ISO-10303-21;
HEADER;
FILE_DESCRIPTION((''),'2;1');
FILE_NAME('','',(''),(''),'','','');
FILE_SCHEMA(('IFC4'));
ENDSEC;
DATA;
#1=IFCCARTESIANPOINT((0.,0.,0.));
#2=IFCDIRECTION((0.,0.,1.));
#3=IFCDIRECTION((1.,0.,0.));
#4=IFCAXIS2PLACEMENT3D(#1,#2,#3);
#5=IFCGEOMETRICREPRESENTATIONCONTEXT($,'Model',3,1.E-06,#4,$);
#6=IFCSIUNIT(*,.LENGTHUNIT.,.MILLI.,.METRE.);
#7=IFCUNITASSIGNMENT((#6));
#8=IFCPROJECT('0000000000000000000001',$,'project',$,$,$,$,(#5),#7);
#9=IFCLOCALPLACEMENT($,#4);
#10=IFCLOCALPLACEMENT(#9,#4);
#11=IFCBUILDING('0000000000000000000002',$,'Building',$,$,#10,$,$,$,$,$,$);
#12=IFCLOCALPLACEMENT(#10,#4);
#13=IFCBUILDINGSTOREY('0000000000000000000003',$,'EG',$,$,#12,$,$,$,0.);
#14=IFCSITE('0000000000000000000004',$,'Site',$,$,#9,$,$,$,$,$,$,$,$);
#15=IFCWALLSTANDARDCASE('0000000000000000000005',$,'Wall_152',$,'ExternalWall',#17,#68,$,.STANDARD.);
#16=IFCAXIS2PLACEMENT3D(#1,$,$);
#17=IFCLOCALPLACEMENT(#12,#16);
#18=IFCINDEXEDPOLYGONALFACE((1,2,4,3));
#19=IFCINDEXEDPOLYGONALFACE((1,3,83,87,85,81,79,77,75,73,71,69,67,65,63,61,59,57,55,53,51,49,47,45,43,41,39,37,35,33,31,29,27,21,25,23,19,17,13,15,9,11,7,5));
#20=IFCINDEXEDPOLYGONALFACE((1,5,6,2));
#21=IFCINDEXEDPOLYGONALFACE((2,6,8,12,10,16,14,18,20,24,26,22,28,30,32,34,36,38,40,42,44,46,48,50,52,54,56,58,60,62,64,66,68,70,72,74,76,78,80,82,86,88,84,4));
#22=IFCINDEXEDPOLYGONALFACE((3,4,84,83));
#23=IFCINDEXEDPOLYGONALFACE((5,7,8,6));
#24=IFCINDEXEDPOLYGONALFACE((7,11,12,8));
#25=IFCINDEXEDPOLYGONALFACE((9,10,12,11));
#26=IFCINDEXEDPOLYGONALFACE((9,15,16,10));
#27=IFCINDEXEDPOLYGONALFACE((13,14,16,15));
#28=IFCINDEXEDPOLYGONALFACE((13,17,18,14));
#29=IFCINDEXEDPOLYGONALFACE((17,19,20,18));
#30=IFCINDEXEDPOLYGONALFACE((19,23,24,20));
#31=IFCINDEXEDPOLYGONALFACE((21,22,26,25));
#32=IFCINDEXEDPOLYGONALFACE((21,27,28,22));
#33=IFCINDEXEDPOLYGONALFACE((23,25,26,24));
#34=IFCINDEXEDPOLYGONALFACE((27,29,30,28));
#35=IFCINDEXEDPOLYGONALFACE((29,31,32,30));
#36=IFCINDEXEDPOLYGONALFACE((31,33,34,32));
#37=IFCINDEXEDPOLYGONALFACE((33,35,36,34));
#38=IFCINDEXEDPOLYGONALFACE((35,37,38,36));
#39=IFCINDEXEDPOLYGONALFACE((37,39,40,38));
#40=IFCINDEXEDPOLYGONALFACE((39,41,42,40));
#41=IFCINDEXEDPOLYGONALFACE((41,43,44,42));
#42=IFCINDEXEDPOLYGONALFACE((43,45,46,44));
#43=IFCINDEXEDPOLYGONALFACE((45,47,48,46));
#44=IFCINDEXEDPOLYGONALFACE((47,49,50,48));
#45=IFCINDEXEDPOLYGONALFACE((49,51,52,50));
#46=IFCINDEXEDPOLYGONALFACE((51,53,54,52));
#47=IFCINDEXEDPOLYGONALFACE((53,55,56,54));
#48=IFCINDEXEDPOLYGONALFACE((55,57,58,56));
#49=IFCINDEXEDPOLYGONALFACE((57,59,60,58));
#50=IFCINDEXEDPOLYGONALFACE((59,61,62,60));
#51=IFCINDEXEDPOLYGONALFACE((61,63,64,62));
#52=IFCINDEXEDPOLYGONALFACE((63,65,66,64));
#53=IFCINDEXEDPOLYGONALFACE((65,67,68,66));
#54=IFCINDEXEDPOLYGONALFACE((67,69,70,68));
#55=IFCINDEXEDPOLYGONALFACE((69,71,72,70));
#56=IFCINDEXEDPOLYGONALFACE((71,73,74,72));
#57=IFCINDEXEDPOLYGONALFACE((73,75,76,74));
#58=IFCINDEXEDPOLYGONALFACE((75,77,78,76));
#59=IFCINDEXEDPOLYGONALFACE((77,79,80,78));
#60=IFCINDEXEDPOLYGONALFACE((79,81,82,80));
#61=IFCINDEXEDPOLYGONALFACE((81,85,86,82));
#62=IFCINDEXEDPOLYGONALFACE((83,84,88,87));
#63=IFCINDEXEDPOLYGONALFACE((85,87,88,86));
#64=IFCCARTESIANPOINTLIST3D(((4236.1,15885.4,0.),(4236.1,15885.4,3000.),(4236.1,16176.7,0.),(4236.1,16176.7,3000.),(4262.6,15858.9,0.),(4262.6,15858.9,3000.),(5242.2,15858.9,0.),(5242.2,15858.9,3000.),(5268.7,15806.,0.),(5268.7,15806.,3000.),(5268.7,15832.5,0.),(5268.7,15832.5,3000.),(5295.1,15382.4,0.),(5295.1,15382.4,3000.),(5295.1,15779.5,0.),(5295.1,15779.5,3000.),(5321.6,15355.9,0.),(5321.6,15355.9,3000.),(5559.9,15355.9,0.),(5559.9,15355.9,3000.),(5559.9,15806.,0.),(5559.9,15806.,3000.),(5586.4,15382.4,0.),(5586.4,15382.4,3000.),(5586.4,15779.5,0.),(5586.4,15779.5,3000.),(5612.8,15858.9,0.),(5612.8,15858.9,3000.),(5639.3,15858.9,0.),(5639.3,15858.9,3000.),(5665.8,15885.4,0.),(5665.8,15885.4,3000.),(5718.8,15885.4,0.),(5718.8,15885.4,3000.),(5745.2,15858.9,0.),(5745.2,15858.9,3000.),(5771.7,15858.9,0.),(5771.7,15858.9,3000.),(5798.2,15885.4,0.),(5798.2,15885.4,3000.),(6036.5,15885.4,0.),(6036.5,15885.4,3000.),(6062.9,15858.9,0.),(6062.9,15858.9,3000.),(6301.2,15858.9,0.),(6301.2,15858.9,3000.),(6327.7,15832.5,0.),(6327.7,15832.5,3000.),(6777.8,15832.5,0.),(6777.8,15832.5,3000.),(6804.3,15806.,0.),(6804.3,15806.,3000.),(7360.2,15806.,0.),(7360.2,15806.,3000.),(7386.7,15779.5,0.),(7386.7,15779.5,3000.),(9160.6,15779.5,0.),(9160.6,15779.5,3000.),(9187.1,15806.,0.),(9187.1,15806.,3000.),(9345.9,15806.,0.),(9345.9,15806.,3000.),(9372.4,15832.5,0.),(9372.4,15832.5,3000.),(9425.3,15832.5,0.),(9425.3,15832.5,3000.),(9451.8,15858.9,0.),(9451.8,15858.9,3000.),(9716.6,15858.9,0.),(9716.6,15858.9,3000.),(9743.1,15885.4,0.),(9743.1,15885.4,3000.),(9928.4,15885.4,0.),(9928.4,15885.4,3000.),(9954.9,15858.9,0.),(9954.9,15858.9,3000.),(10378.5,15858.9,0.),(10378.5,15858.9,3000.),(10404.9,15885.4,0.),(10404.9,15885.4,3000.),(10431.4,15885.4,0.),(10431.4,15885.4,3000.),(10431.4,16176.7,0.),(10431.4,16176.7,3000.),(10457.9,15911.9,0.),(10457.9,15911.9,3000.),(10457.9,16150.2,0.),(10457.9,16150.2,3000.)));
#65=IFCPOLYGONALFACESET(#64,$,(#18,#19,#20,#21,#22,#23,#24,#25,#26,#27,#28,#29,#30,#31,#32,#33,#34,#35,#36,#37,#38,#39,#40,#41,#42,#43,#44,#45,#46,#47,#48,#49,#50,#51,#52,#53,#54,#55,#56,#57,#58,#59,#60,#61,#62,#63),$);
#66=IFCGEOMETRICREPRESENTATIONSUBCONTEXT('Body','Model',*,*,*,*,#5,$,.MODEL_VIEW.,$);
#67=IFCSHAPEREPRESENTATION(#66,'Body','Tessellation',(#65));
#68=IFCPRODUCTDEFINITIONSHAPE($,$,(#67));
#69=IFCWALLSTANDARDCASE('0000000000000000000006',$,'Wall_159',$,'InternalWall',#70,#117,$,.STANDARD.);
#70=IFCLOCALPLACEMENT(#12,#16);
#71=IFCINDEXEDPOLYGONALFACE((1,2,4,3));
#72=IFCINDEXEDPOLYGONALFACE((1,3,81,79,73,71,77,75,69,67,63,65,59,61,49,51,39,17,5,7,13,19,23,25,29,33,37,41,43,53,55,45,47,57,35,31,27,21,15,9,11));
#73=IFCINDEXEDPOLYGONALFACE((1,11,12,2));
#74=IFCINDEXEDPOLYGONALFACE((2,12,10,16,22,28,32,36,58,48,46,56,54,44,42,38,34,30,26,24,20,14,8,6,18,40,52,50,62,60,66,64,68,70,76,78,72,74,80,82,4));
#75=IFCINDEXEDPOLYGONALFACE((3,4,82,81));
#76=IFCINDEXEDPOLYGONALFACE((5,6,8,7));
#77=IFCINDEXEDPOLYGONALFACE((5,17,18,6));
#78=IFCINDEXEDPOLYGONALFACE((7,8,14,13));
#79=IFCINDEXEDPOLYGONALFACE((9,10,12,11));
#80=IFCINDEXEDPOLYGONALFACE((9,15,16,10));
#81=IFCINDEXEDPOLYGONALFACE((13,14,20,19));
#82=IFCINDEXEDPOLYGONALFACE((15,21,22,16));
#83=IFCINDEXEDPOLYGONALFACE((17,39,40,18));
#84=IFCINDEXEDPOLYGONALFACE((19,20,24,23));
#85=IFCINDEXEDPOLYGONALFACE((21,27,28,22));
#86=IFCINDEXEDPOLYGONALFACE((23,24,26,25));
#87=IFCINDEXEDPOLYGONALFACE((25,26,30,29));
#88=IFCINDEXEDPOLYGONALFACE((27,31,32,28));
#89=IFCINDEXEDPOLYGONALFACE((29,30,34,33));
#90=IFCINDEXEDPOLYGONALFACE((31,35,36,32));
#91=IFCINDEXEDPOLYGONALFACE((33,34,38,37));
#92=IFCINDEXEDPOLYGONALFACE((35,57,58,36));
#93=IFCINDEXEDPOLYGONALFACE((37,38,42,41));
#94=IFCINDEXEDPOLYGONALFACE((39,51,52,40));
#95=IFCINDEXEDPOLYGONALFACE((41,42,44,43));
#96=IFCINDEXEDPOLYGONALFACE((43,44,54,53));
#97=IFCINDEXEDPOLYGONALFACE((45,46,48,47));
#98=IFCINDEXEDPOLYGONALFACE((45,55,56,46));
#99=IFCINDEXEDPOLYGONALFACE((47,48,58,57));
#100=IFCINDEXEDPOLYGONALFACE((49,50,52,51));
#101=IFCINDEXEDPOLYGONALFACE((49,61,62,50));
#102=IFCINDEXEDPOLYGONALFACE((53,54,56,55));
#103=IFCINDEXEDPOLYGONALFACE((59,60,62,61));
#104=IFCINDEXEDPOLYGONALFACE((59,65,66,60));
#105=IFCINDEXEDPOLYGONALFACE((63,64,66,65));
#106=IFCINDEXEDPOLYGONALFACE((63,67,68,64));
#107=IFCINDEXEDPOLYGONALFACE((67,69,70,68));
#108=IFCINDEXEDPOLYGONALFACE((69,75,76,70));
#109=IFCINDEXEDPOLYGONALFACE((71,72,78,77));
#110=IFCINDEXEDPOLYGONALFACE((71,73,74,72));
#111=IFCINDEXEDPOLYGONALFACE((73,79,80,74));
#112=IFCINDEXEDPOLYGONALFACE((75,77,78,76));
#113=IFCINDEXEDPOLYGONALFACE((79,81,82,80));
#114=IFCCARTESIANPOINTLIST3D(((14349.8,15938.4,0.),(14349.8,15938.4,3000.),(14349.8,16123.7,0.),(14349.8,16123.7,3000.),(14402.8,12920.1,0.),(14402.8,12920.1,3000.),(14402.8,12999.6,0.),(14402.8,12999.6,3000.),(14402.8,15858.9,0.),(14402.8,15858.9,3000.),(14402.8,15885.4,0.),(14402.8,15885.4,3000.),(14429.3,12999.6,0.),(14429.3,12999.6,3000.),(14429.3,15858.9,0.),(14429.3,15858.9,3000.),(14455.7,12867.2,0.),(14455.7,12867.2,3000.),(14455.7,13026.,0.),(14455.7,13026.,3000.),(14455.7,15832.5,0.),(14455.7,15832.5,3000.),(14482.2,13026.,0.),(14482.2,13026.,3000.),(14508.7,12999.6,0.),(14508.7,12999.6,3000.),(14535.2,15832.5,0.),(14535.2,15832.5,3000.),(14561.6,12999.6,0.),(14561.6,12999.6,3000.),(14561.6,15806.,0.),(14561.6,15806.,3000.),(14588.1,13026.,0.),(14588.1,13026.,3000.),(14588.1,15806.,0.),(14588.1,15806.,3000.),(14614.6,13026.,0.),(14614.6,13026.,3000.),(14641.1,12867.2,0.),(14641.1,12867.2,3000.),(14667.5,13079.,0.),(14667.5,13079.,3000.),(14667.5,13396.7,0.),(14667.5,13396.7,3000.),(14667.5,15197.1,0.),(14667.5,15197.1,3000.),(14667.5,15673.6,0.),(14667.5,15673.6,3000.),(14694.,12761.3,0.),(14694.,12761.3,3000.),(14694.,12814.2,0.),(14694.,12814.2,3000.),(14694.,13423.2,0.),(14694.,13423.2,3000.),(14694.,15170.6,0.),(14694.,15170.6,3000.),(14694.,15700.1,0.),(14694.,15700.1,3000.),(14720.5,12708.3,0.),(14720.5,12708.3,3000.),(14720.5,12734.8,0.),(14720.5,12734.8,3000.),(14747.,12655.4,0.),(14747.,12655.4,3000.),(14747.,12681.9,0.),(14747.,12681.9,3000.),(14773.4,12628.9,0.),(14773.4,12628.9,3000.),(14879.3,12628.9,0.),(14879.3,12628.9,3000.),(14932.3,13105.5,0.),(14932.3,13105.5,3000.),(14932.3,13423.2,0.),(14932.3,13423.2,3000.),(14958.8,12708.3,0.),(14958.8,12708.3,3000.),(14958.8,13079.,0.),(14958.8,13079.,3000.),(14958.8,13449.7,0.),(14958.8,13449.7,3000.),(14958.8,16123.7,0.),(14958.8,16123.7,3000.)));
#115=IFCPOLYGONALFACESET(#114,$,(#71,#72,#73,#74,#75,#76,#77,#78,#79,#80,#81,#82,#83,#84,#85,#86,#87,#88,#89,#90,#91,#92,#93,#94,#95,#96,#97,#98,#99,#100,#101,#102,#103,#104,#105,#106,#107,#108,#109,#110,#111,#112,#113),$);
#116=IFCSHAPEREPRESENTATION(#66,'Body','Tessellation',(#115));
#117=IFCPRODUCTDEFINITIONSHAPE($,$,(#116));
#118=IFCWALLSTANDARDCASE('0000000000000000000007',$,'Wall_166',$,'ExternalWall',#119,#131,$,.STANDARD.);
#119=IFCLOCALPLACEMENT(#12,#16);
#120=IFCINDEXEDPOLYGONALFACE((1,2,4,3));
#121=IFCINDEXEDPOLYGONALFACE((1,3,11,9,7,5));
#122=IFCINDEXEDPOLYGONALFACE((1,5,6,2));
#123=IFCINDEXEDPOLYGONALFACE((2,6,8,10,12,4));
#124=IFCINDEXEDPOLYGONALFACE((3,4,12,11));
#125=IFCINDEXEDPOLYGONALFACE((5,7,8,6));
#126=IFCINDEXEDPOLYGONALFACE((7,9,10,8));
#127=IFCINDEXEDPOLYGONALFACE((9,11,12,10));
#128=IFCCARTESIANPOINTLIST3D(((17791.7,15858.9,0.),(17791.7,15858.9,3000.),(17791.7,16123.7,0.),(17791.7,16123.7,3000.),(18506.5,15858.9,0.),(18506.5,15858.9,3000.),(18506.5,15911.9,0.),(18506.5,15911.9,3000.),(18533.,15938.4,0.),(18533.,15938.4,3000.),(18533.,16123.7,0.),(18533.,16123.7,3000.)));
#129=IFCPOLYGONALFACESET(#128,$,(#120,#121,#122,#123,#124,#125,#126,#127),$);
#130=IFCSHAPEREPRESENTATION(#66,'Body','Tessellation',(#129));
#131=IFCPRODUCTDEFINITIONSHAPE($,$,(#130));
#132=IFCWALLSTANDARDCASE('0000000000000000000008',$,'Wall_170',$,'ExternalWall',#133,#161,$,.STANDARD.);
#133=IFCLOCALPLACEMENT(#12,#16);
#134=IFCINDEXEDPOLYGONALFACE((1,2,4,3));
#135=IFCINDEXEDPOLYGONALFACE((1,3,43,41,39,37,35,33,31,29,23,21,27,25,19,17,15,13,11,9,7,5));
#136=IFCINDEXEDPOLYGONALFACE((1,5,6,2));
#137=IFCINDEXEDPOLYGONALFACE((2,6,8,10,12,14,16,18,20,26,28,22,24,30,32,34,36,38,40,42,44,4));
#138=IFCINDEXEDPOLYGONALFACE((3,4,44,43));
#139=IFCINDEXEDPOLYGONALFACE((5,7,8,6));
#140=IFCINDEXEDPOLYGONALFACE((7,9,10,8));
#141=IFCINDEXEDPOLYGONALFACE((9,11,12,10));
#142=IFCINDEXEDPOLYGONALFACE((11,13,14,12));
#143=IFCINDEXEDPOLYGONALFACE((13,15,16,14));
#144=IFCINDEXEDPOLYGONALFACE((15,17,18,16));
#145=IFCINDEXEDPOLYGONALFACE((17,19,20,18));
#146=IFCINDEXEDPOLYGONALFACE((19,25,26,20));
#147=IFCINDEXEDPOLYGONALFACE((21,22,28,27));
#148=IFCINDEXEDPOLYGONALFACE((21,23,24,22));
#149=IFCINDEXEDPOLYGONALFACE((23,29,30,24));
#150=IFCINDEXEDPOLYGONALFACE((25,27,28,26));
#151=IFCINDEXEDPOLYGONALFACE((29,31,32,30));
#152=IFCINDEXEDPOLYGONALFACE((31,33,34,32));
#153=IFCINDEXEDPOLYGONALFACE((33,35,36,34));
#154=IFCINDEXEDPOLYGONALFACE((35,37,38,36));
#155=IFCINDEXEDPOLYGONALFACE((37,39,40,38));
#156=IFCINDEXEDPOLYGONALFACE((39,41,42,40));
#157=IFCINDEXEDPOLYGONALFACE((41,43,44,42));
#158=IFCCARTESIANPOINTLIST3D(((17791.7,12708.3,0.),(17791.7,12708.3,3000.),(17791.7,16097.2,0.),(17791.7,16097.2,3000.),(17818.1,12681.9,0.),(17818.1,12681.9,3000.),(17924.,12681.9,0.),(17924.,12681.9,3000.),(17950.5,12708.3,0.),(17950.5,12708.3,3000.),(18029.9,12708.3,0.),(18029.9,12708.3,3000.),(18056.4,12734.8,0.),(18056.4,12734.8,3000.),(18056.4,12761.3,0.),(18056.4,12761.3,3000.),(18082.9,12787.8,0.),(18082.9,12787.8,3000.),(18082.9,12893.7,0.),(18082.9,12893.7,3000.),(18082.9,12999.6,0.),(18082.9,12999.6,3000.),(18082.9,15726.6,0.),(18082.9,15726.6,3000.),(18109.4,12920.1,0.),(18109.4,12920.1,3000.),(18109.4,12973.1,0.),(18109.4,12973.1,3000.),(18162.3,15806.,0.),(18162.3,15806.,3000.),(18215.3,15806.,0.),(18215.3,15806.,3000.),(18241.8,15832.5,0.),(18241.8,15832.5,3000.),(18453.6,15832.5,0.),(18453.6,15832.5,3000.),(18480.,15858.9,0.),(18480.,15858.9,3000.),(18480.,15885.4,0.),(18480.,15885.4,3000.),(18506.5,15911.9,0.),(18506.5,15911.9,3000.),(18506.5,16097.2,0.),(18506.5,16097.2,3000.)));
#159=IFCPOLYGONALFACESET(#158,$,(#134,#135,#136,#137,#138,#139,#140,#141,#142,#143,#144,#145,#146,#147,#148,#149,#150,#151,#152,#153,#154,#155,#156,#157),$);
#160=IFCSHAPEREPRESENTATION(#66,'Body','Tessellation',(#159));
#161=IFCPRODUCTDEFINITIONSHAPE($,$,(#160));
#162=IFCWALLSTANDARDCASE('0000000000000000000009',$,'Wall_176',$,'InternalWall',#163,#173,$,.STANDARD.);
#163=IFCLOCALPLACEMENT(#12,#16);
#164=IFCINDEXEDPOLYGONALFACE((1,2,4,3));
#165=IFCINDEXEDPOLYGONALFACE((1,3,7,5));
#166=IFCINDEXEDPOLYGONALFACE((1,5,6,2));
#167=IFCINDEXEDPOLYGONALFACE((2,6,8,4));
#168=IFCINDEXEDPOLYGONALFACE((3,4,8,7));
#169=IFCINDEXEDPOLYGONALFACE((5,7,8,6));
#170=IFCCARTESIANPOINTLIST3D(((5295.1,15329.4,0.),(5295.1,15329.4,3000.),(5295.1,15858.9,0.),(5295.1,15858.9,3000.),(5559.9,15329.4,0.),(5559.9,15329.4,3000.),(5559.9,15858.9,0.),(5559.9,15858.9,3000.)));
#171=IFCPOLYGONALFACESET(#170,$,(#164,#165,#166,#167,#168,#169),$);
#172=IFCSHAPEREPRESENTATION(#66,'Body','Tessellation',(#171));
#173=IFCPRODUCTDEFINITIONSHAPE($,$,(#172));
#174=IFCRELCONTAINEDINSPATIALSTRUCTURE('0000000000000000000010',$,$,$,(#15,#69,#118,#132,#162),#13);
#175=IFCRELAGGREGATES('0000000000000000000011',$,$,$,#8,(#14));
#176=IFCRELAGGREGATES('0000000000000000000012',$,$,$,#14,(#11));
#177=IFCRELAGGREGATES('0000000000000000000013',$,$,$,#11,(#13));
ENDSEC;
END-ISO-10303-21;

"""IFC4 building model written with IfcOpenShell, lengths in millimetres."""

from ifc_helpers import new_model, si_unit, frame, origin_with_axes, place, context, subcontext, project, spatial, polyline, outline, extrude, element, save


model = new_model("IFC4")

# Units and contexts
model_context = context("Model", 3, precision=1e-06, world=origin_with_axes())
body_context = subcontext(model_context, "Body", "Model", "MODEL_VIEW")
ifc_project = project(units=[si_unit("LENGTHUNIT", "METRE", prefix="MILLI")], contexts=[model_context])

# Site, building, storey
site_placement = place(None, origin_with_axes())
site = spatial("IfcSite", under=ifc_project, at=site_placement, Name="Site")
building_placement = place(site_placement, origin_with_axes())
building = spatial("IfcBuilding", under=site, at=building_placement, Name="Building")
storey_placement = place(building_placement, origin_with_axes())
storey = spatial("IfcBuildingStorey", under=building, at=storey_placement, Name="EG", Elevation=0.0)

# Walls
wall_1_placement = place(storey_placement, origin_with_axes())
element("IfcWallStandardCase", 1, at=wall_1_placement, inside=storey, Name="Wall_152", ObjectType="ExternalWall", PredefinedType="STANDARD", context=body_context, shape_type="SweptSolid", body=[
    extrude(outline(polyline([(5321.6, 15355.9, 0.0), (5295.1, 15382.4, 0.0), (5295.1, 15779.5, 0.0), (5268.7, 15806.0, 0.0), (5268.7, 15832.5, 0.0), (5242.2, 15858.9, 0.0), (4262.6, 15858.9, 0.0), (4236.1, 15885.4, 0.0), (4236.1, 16176.7, 0.0), (10431.4, 16176.7, 0.0), (10457.9, 16150.2, 0.0), (10457.9, 15911.9, 0.0), (10431.4, 15885.4, 0.0), (10404.9, 15885.4, 0.0), (10378.5, 15858.9, 0.0), (9954.9, 15858.9, 0.0), (9928.4, 15885.4, 0.0), (9743.1, 15885.4, 0.0), (9716.6, 15858.9, 0.0), (9451.8, 15858.9, 0.0), (9425.3, 15832.5, 0.0), (9372.4, 15832.5, 0.0), (9345.9, 15806.0, 0.0), (9187.1, 15806.0, 0.0), (9160.6, 15779.5, 0.0), (7386.7, 15779.5, 0.0), (7360.2, 15806.0, 0.0), (6804.3, 15806.0, 0.0), (6777.8, 15832.5, 0.0), (6327.7, 15832.5, 0.0), (6301.2, 15858.9, 0.0), (6062.9, 15858.9, 0.0), (6036.5, 15885.4, 0.0), (5798.2, 15885.4, 0.0), (5771.7, 15858.9, 0.0), (5745.2, 15858.9, 0.0), (5718.8, 15885.4, 0.0), (5665.8, 15885.4, 0.0), (5639.3, 15858.9, 0.0), (5612.8, 15858.9, 0.0), (5559.9, 15806.0, 0.0), (5586.4, 15779.5, 0.0), (5586.4, 15382.4, 0.0), (5559.9, 15355.9, 0.0), (5321.6, 15355.9, 0.0)])), origin_with_axes(), (0.0, 0.0, 1.0), 3000.0),
])
wall_2_placement = place(storey_placement, origin_with_axes())
element("IfcWallStandardCase", 2, at=wall_2_placement, inside=storey, Name="Wall_159", ObjectType="InternalWall", PredefinedType="STANDARD", context=body_context, shape_type="SweptSolid", body=[
    extrude(outline(polyline([(14773.4, 12628.9, 0.0), (14747.0, 12655.4, 0.0), (14747.0, 12681.9, 0.0), (14720.5, 12708.3, 0.0), (14720.5, 12734.8, 0.0), (14694.0, 12761.3, 0.0), (14694.0, 12814.2, 0.0), (14641.1, 12867.2, 0.0), (14455.7, 12867.2, 0.0), (14402.8, 12920.1, 0.0), (14402.8, 12999.6, 0.0), (14429.3, 12999.6, 0.0), (14455.7, 13026.0, 0.0), (14482.2, 13026.0, 0.0), (14508.7, 12999.6, 0.0), (14561.6, 12999.6, 0.0), (14588.1, 13026.0, 0.0), (14614.6, 13026.0, 0.0), (14667.5, 13079.0, 0.0), (14667.5, 13396.7, 0.0), (14694.0, 13423.2, 0.0), (14694.0, 15170.6, 0.0), (14667.5, 15197.1, 0.0), (14667.5, 15673.6, 0.0), (14694.0, 15700.1, 0.0), (14588.1, 15806.0, 0.0), (14561.6, 15806.0, 0.0), (14535.2, 15832.5, 0.0), (14455.7, 15832.5, 0.0), (14429.3, 15858.9, 0.0), (14402.8, 15858.9, 0.0), (14402.8, 15885.4, 0.0), (14349.8, 15938.4, 0.0), (14349.8, 16123.7, 0.0), (14958.8, 16123.7, 0.0), (14958.8, 13449.7, 0.0), (14932.3, 13423.2, 0.0), (14932.3, 13105.5, 0.0), (14958.8, 13079.0, 0.0), (14958.8, 12708.3, 0.0), (14879.3, 12628.9, 0.0), (14773.4, 12628.9, 0.0)])), origin_with_axes(), (0.0, 0.0, 1.0), 3000.0),
])
for number, where, z_axis, x_axis, name in (
    (3, (0.0, 0.0, 0.0), (0.0, 0.0, 1.0), (1.0, 0.0, 0.0), "Wall_166"),
):
    element("IfcWallStandardCase", number, at=place(storey_placement, frame(where, z_axis=z_axis, x_axis=x_axis)), inside=storey, Name=name, ObjectType="ExternalWall", PredefinedType="STANDARD", context=body_context, shape_type="SweptSolid", body=[
        extrude(outline(polyline([(17791.7, 15858.9, 0.0), (17791.7, 16123.7, 0.0), (18533.0, 16123.7, 0.0), (18533.0, 15938.4, 0.0), (18506.5, 15911.9, 0.0), (18506.5, 15858.9, 0.0), (17791.7, 15858.9, 0.0)])), origin_with_axes(), (0.0, 0.0, 1.0), 3000.0),
    ])
for number, where, z_axis, x_axis, name in (
    (4, (0.0, 0.0, 0.0), (0.0, 0.0, 1.0), (1.0, 0.0, 0.0), "Wall_170"),
):
    element("IfcWallStandardCase", number, at=place(storey_placement, frame(where, z_axis=z_axis, x_axis=x_axis)), inside=storey, Name=name, ObjectType="ExternalWall", PredefinedType="STANDARD", context=body_context, shape_type="SweptSolid", body=[
        extrude(outline(polyline([(17818.1, 12681.9, 0.0), (17791.7, 12708.3, 0.0), (17791.7, 16097.2, 0.0), (18506.5, 16097.2, 0.0), (18506.5, 15911.9, 0.0), (18480.0, 15885.4, 0.0), (18480.0, 15858.9, 0.0), (18453.6, 15832.5, 0.0), (18241.8, 15832.5, 0.0), (18215.3, 15806.0, 0.0), (18162.3, 15806.0, 0.0), (18082.9, 15726.6, 0.0), (18082.9, 12999.6, 0.0), (18109.4, 12973.1, 0.0), (18109.4, 12920.1, 0.0), (18082.9, 12893.7, 0.0), (18082.9, 12787.8, 0.0), (18056.4, 12761.3, 0.0), (18056.4, 12734.8, 0.0), (18029.9, 12708.3, 0.0), (17950.5, 12708.3, 0.0), (17924.0, 12681.9, 0.0), (17818.1, 12681.9, 0.0)])), origin_with_axes(), (0.0, 0.0, 1.0), 3000.0),
    ])
wall_3_placement = place(storey_placement, origin_with_axes())
element("IfcWallStandardCase", 5, at=wall_3_placement, inside=storey, Name="Wall_176", ObjectType="InternalWall", PredefinedType="STANDARD", context=body_context, shape_type="SweptSolid", body=[
    extrude(outline(polyline([(5295.1, 15329.4, 0.0), (5295.1, 15858.9, 0.0), (5559.9, 15858.9, 0.0), (5559.9, 15329.4, 0.0), (5295.1, 15329.4, 0.0)])), origin_with_axes(), (0.0, 0.0, 1.0), 3000.0),
])

save(model, "model.ifc")
